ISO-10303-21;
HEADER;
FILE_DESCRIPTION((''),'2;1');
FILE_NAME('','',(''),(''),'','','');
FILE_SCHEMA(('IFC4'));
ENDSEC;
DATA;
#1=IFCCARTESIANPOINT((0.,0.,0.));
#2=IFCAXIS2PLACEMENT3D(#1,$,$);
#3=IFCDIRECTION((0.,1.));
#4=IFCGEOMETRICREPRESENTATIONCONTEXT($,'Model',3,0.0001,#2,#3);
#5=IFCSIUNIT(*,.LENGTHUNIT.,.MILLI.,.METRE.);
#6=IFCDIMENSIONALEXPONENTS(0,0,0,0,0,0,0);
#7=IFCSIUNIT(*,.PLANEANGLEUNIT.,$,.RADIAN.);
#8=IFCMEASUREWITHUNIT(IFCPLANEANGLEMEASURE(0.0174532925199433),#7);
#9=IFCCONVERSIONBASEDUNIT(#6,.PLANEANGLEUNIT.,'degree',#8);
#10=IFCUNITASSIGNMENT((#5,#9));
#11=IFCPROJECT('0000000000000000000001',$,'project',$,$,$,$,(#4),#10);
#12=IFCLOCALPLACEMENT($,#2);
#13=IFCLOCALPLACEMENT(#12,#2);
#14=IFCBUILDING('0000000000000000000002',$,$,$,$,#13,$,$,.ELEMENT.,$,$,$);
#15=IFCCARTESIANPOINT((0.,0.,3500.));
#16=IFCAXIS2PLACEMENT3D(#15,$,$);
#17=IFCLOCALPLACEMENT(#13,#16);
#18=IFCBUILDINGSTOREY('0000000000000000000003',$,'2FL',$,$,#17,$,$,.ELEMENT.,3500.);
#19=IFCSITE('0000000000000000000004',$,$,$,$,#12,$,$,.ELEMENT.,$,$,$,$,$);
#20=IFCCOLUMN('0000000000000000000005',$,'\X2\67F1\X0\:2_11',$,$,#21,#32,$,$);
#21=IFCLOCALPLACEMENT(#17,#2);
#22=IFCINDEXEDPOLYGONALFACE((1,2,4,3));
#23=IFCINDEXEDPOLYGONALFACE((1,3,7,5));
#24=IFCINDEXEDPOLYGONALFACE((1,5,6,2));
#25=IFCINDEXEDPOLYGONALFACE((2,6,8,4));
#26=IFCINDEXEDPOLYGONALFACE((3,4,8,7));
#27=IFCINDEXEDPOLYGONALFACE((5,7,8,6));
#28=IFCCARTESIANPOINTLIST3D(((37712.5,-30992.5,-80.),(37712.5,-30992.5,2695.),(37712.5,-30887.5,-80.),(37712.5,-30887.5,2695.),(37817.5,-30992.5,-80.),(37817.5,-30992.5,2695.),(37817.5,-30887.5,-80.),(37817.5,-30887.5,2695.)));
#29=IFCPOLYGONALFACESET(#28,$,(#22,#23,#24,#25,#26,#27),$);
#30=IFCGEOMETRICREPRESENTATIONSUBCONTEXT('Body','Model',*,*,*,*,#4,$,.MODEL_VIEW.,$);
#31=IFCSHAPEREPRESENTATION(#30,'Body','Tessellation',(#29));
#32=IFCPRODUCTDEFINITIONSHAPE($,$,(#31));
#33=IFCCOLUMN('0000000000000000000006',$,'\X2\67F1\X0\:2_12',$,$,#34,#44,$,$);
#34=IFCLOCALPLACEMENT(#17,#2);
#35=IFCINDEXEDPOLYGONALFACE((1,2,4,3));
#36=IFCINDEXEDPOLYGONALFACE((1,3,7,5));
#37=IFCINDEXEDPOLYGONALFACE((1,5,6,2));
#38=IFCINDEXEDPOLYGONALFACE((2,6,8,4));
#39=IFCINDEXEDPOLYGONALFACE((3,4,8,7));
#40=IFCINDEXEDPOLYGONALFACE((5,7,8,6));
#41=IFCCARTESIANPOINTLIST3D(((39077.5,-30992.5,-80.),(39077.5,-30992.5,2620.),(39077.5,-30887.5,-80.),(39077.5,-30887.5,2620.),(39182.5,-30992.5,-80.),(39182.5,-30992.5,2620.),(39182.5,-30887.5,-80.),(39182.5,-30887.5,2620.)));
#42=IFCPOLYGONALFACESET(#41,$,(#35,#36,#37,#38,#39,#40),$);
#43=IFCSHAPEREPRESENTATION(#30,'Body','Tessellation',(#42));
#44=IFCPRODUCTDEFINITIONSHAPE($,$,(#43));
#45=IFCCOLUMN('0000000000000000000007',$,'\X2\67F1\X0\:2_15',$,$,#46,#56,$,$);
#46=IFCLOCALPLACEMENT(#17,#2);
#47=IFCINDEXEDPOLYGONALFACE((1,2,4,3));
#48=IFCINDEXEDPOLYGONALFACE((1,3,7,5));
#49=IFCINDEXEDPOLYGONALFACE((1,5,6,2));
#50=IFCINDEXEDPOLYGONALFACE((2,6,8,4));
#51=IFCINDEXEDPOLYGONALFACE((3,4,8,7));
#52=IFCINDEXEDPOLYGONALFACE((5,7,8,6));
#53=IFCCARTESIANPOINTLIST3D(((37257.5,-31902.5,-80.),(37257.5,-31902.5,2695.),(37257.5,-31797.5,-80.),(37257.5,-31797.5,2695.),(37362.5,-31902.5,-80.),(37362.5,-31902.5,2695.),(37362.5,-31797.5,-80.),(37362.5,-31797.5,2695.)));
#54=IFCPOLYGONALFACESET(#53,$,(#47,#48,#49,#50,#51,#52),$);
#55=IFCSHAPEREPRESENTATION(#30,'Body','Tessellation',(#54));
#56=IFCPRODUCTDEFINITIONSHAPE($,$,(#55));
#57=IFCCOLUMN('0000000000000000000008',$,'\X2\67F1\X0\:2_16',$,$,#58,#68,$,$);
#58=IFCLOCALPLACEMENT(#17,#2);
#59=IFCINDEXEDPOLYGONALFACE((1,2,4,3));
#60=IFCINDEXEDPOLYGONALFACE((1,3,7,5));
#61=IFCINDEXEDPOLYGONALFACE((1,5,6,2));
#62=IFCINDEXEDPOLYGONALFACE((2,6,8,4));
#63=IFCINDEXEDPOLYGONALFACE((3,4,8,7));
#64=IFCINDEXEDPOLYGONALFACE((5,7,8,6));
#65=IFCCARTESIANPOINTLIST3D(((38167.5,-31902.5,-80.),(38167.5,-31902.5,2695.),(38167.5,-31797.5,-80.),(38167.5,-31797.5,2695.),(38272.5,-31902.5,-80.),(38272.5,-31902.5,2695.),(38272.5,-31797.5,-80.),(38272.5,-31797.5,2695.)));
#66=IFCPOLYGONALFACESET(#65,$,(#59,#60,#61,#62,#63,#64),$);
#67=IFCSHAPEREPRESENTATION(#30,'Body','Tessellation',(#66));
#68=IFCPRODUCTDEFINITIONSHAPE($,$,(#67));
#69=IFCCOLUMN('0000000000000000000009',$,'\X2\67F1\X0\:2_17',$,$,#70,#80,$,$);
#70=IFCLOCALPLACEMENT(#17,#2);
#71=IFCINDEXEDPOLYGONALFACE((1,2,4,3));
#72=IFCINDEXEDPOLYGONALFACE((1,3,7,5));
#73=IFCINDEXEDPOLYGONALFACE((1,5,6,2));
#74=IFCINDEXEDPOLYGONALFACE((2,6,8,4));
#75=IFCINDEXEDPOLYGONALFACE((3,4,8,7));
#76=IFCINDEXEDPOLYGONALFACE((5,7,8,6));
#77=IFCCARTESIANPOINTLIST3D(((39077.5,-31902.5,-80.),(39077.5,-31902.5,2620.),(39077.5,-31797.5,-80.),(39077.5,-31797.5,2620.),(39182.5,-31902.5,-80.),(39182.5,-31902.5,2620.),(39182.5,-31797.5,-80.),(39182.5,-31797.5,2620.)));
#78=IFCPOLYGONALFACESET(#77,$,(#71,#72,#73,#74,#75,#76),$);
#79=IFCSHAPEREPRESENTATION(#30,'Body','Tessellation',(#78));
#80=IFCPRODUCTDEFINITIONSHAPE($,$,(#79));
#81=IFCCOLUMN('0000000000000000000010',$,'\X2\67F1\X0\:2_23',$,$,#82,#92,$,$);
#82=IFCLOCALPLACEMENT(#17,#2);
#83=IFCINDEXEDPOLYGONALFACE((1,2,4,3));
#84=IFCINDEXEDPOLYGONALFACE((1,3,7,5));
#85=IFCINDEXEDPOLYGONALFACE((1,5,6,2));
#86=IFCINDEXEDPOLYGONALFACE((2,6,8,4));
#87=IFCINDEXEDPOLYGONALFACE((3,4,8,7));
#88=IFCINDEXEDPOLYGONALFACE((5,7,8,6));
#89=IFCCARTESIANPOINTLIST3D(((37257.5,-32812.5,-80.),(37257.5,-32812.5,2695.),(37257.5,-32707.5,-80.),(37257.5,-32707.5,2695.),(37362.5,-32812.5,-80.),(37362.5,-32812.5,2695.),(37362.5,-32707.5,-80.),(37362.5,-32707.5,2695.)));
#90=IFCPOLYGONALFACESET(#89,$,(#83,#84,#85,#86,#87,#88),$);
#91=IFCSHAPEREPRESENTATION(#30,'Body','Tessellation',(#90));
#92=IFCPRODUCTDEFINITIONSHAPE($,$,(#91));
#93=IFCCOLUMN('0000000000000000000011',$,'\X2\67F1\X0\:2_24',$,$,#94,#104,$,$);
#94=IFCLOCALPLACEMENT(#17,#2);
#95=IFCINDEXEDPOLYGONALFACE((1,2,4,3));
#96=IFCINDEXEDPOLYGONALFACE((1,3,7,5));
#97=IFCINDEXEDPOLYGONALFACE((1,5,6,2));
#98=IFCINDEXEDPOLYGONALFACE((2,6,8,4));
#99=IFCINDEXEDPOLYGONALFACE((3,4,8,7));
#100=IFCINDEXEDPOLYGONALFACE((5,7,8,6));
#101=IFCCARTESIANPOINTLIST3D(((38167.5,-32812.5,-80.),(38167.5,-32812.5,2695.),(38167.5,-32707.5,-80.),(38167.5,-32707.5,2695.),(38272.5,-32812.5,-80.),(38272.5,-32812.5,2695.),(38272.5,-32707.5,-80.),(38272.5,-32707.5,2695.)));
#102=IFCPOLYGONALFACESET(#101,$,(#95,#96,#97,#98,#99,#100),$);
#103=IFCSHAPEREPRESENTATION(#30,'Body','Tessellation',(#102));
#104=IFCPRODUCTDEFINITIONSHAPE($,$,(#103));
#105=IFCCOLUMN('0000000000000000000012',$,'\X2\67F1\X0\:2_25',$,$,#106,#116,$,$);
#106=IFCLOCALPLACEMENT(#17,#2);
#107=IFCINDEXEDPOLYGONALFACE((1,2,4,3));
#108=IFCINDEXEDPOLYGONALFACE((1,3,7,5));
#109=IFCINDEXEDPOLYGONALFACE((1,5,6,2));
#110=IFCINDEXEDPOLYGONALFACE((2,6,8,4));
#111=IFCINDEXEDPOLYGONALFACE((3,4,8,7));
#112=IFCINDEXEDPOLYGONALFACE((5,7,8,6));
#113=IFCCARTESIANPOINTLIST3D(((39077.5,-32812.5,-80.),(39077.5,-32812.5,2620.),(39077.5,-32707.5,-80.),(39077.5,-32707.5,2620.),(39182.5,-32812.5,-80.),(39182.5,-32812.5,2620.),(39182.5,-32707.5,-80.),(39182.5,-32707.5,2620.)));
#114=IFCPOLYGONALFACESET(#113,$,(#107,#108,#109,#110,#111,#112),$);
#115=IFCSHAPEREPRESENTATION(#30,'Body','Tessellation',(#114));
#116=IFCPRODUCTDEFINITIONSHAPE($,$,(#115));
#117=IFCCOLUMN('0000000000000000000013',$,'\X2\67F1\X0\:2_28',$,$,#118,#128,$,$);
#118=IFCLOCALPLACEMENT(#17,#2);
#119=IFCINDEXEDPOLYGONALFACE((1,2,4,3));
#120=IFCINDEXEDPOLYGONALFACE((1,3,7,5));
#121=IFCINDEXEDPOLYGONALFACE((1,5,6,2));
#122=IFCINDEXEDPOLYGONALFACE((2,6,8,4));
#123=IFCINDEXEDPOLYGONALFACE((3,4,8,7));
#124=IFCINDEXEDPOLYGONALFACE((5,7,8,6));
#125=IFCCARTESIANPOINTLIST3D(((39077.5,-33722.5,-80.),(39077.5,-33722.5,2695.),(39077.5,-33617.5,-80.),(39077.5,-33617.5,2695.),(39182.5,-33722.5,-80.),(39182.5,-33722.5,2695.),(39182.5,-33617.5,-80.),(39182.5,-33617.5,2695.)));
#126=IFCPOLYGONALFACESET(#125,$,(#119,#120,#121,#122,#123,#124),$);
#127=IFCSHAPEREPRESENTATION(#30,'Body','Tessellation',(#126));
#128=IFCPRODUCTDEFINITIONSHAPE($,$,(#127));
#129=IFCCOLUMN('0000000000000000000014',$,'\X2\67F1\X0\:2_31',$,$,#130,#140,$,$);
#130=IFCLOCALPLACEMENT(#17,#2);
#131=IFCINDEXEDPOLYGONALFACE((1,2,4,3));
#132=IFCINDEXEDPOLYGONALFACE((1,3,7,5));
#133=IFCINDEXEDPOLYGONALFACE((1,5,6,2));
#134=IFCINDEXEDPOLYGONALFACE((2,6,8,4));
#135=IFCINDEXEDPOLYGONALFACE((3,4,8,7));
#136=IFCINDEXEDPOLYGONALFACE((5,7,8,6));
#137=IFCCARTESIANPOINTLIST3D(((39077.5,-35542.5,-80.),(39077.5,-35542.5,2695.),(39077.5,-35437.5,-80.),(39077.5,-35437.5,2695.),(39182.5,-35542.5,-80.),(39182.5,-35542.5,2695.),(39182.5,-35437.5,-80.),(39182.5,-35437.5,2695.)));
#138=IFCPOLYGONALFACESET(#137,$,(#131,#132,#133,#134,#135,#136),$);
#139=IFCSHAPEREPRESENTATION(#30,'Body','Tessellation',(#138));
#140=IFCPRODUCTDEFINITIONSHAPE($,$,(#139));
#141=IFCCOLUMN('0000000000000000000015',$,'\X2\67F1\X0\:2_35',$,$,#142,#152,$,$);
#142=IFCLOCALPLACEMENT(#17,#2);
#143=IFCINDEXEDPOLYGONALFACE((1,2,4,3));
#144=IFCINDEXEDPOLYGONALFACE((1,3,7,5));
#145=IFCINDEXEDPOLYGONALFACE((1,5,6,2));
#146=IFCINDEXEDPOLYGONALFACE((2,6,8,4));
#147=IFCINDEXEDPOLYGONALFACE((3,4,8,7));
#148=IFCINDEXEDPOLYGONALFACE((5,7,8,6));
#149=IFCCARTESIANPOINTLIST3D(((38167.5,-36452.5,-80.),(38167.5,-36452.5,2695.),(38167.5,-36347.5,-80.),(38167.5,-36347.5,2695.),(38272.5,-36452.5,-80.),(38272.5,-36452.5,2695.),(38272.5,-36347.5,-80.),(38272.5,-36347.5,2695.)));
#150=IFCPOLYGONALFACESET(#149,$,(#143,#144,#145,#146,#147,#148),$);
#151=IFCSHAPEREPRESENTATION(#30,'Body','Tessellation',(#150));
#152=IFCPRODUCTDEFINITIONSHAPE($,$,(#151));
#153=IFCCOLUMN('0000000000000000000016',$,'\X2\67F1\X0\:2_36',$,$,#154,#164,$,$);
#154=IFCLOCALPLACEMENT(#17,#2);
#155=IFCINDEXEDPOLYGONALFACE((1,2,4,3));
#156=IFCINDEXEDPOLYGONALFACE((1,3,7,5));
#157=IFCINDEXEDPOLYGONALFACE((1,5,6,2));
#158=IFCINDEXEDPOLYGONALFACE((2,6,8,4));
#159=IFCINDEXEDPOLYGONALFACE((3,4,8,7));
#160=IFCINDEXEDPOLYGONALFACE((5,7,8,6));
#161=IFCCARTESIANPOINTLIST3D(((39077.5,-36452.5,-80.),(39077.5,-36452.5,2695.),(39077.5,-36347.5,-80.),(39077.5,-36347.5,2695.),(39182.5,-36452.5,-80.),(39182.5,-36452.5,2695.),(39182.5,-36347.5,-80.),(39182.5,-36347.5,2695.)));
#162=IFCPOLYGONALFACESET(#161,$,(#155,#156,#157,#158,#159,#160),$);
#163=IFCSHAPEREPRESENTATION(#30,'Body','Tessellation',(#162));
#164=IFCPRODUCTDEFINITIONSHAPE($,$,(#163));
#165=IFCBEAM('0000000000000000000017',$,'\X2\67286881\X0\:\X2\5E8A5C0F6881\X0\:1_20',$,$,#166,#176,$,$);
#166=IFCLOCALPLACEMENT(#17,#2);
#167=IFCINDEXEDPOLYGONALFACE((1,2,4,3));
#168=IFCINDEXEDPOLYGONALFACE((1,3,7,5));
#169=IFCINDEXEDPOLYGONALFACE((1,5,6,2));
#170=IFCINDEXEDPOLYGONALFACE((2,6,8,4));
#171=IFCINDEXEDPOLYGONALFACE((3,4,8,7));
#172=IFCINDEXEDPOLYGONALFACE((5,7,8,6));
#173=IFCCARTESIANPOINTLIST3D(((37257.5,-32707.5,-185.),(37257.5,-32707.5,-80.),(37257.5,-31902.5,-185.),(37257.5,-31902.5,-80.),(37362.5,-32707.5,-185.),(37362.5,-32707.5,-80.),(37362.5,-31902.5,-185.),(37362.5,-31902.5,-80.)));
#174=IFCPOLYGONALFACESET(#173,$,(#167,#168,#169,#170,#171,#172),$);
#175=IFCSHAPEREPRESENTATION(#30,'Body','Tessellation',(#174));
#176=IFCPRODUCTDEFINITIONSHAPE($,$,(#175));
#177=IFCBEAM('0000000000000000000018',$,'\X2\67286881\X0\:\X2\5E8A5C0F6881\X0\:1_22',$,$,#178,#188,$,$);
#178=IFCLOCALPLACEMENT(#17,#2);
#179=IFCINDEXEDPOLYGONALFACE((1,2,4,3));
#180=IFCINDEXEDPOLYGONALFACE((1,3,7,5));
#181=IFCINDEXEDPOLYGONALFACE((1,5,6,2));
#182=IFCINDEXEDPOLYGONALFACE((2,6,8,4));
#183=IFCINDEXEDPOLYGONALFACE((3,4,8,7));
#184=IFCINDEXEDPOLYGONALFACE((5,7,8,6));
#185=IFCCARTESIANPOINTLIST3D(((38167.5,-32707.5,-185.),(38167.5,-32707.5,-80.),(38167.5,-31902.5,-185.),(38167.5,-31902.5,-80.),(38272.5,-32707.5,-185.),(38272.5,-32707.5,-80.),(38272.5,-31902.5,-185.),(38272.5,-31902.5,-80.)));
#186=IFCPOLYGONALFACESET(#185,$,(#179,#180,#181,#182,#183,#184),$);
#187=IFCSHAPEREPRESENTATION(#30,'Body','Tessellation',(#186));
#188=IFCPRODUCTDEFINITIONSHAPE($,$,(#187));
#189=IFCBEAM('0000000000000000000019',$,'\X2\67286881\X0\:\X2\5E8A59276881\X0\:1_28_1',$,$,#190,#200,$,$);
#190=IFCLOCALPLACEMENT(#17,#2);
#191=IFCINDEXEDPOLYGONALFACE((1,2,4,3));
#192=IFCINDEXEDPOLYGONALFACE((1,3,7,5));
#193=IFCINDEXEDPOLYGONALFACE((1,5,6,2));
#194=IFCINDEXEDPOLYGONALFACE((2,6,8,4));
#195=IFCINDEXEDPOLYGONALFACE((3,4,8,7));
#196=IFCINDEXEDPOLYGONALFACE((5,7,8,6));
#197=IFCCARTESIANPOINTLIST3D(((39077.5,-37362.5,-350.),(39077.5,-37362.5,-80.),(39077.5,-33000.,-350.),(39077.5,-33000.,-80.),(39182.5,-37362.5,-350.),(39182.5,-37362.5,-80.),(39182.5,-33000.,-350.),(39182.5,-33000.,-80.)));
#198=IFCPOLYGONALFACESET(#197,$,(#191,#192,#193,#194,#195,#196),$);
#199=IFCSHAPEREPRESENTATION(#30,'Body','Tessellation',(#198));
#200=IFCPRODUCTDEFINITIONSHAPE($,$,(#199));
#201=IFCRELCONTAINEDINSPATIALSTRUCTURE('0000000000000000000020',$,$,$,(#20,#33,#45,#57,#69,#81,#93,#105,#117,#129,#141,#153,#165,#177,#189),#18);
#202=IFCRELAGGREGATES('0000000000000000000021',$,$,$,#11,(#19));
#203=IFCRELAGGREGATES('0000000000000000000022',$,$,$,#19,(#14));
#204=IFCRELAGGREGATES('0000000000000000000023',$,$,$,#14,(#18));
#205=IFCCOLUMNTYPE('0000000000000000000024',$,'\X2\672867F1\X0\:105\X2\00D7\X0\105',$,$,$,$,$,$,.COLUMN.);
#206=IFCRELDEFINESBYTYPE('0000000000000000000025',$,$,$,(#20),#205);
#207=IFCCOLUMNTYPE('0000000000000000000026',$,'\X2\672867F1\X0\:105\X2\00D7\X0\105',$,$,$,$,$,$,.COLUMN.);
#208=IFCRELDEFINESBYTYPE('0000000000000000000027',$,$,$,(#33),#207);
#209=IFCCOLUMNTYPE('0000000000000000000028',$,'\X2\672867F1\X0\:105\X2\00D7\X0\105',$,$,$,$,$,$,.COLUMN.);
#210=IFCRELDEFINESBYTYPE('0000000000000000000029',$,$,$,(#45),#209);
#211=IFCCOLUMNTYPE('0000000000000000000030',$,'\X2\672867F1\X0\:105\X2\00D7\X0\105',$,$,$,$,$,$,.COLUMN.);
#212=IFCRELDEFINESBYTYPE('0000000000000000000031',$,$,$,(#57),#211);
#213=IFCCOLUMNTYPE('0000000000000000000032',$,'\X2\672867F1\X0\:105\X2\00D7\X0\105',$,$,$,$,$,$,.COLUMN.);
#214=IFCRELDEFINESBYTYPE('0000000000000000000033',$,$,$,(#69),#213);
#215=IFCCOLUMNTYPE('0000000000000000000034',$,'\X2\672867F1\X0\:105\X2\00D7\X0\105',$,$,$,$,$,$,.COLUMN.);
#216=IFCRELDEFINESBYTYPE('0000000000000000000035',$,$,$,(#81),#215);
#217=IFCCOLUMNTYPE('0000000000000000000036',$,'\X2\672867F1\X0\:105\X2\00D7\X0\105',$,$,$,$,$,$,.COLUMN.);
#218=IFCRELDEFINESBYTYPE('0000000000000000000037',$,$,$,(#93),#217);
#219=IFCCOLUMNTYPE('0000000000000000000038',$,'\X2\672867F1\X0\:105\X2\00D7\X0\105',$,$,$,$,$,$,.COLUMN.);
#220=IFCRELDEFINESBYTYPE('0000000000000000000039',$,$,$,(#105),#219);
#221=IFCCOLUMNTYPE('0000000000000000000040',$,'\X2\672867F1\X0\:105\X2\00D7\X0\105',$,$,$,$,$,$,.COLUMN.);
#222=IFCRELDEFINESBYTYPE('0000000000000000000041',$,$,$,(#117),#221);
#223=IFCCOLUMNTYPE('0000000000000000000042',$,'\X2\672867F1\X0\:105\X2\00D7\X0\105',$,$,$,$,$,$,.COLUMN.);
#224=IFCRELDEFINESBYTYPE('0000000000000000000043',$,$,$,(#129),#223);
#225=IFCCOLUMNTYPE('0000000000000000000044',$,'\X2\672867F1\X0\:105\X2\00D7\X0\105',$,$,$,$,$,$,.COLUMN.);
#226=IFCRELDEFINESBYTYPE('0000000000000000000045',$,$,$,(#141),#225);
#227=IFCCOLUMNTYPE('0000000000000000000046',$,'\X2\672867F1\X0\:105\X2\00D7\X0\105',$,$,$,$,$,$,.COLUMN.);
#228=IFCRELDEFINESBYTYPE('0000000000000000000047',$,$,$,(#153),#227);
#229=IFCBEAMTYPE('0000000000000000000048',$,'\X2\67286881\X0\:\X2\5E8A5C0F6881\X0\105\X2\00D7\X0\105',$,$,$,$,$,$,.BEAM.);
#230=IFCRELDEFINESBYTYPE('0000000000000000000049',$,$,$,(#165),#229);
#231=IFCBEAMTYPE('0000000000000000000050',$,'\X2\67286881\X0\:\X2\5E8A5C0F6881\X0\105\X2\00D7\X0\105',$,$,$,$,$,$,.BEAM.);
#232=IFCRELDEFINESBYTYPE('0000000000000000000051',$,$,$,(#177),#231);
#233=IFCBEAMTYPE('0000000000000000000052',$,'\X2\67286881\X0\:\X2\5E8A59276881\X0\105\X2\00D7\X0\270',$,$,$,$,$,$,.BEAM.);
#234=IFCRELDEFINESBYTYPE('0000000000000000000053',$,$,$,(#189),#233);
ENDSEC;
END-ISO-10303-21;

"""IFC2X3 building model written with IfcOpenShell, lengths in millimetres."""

from ifc_helpers import new_model, entity, si_unit, converted_unit, direction, frame, origin, origin_with_axes, origin_2d, place, context, subcontext, project, spatial, rectangle, extrude, type_object, element, save


model = new_model("IFC2X3")

# Units and contexts
model_context = context("Model", 3, precision=0.0001, world=origin(), true_north=direction((0.0, 1.0)))
body_context = subcontext(model_context, "Body", "Model", "MODEL_VIEW")
ifc_project = project(units=[si_unit("LENGTHUNIT", "METRE", prefix="MILLI"), converted_unit("PLANEANGLEUNIT", "degree", entity("IfcPlaneAngleMeasure", 0.0174532925199433), si_unit("PLANEANGLEUNIT", "RADIAN"), dimensions=[0, 0, 0, 0, 0, 0, 0])], contexts=[model_context])

# Site, building, storey
site_placement = place(None, origin())
site = spatial("IfcSite", under=ifc_project, at=site_placement, CompositionType="ELEMENT")
building_placement = place(site_placement, origin())
building = spatial("IfcBuilding", under=site, at=building_placement, CompositionType="ELEMENT")
storey_placement = place(building_placement, frame((0.0, 0.0, 3500.0)))
storey = spatial("IfcBuildingStorey", under=building, at=storey_placement, Name="2FL", CompositionType="ELEMENT", Elevation=3500.0)

# Columns
column_type_1 = type_object("IfcColumnType", Name="木柱:105×105", PredefinedType="COLUMN")
column_1_placement = place(storey_placement, frame((37765.0, -30940.0, -80.0)))
element("IfcColumn", 1, at=column_1_placement, inside=storey, type_object=column_type_1, Name="柱:2_11", context=body_context, shape_type="SweptSolid", body=[
    extrude(rectangle(XDim=105.0, YDim=105.0, at=origin_2d()), origin_with_axes(), (0.0, 0.0, 1.0), 2775.0),
])
column_type_2 = type_object("IfcColumnType", Name="木柱:105×105", PredefinedType="COLUMN")
column_2_placement = place(storey_placement, frame((39130.0, -30940.0, -80.0)))
element("IfcColumn", 2, at=column_2_placement, inside=storey, type_object=column_type_2, Name="柱:2_12", context=body_context, shape_type="SweptSolid", body=[
    extrude(rectangle(XDim=105.0, YDim=105.0, at=origin_2d()), origin_with_axes(), (0.0, 0.0, 1.0), 2700.0),
])
column_type_3 = type_object("IfcColumnType", Name="木柱:105×105", PredefinedType="COLUMN")
column_3_placement = place(storey_placement, frame((37310.0, -31850.0, -80.0)))
element("IfcColumn", 3, at=column_3_placement, inside=storey, type_object=column_type_3, Name="柱:2_15", context=body_context, shape_type="SweptSolid", body=[
    extrude(rectangle(XDim=105.0, YDim=105.0, at=origin_2d()), origin_with_axes(), (0.0, 0.0, 1.0), 2775.0),
])
column_type_4 = type_object("IfcColumnType", Name="木柱:105×105", PredefinedType="COLUMN")
column_4_placement = place(storey_placement, frame((38220.0, -31850.0, -80.0)))
element("IfcColumn", 4, at=column_4_placement, inside=storey, type_object=column_type_4, Name="柱:2_16", context=body_context, shape_type="SweptSolid", body=[
    extrude(rectangle(XDim=105.0, YDim=105.0, at=origin_2d()), origin_with_axes(), (0.0, 0.0, 1.0), 2775.0),
])
column_type_5 = type_object("IfcColumnType", Name="木柱:105×105", PredefinedType="COLUMN")
column_5_placement = place(storey_placement, frame((39130.0, -31850.0, -80.0)))
element("IfcColumn", 5, at=column_5_placement, inside=storey, type_object=column_type_5, Name="柱:2_17", context=body_context, shape_type="SweptSolid", body=[
    extrude(rectangle(XDim=105.0, YDim=105.0, at=origin_2d()), origin_with_axes(), (0.0, 0.0, 1.0), 2700.0),
])
column_type_6 = type_object("IfcColumnType", Name="木柱:105×105", PredefinedType="COLUMN")
column_6_placement = place(storey_placement, frame((37310.0, -32760.0, -80.0)))
element("IfcColumn", 6, at=column_6_placement, inside=storey, type_object=column_type_6, Name="柱:2_23", context=body_context, shape_type="SweptSolid", body=[
    extrude(rectangle(XDim=105.0, YDim=105.0, at=origin_2d()), origin_with_axes(), (0.0, 0.0, 1.0), 2775.0),
])
column_type_7 = type_object("IfcColumnType", Name="木柱:105×105", PredefinedType="COLUMN")
column_7_placement = place(storey_placement, frame((38220.0, -32760.0, -80.0)))
element("IfcColumn", 7, at=column_7_placement, inside=storey, type_object=column_type_7, Name="柱:2_24", context=body_context, shape_type="SweptSolid", body=[
    extrude(rectangle(XDim=105.0, YDim=105.0, at=origin_2d()), origin_with_axes(), (0.0, 0.0, 1.0), 2775.0),
])
column_type_8 = type_object("IfcColumnType", Name="木柱:105×105", PredefinedType="COLUMN")
column_8_placement = place(storey_placement, frame((39130.0, -32760.0, -80.0)))
element("IfcColumn", 8, at=column_8_placement, inside=storey, type_object=column_type_8, Name="柱:2_25", context=body_context, shape_type="SweptSolid", body=[
    extrude(rectangle(XDim=105.0, YDim=105.0, at=origin_2d()), origin_with_axes(), (0.0, 0.0, 1.0), 2700.0),
])
column_type_9 = type_object("IfcColumnType", Name="木柱:105×105", PredefinedType="COLUMN")
column_9_placement = place(storey_placement, frame((39130.0, -33670.0, -80.0)))
element("IfcColumn", 9, at=column_9_placement, inside=storey, type_object=column_type_9, Name="柱:2_28", context=body_context, shape_type="SweptSolid", body=[
    extrude(rectangle(XDim=105.0, YDim=105.0, at=origin_2d()), origin_with_axes(), (0.0, 0.0, 1.0), 2775.0),
])
column_type_10 = type_object("IfcColumnType", Name="木柱:105×105", PredefinedType="COLUMN")
column_10_placement = place(storey_placement, frame((39130.0, -35490.0, -80.0)))
element("IfcColumn", 10, at=column_10_placement, inside=storey, type_object=column_type_10, Name="柱:2_31", context=body_context, shape_type="SweptSolid", body=[
    extrude(rectangle(XDim=105.0, YDim=105.0, at=origin_2d()), origin_with_axes(), (0.0, 0.0, 1.0), 2775.0),
])
column_type_11 = type_object("IfcColumnType", Name="木柱:105×105", PredefinedType="COLUMN")
column_11_placement = place(storey_placement, frame((38220.0, -36400.0, -80.0)))
element("IfcColumn", 11, at=column_11_placement, inside=storey, type_object=column_type_11, Name="柱:2_35", context=body_context, shape_type="SweptSolid", body=[
    extrude(rectangle(XDim=105.0, YDim=105.0, at=origin_2d()), origin_with_axes(), (0.0, 0.0, 1.0), 2775.0),
])
column_type_12 = type_object("IfcColumnType", Name="木柱:105×105", PredefinedType="COLUMN")
column_12_placement = place(storey_placement, frame((39130.0, -36400.0, -80.0)))
element("IfcColumn", 12, at=column_12_placement, inside=storey, type_object=column_type_12, Name="柱:2_36", context=body_context, shape_type="SweptSolid", body=[
    extrude(rectangle(XDim=105.0, YDim=105.0, at=origin_2d()), origin_with_axes(), (0.0, 0.0, 1.0), 2775.0),
])

# Beams
beam_type_1 = type_object("IfcBeamType", Name="木梁:床小梁105×105", PredefinedType="BEAM")
beam_1_placement = place(storey_placement, frame((37310.0, -31902.5, -132.5), z_axis=(0.0, -1.0, 0.0), x_axis=(1.0, 0.0, 0.0)))
element("IfcBeam", 13, at=beam_1_placement, inside=storey, type_object=beam_type_1, Name="木梁:床小梁:1_20", context=body_context, shape_type="SweptSolid", body=[
    extrude(rectangle(XDim=105.0, YDim=105.0, at=origin_2d()), origin_with_axes(), (0.0, 0.0, 1.0), 805.0),
])
beam_type_2 = type_object("IfcBeamType", Name="木梁:床小梁105×105", PredefinedType="BEAM")
beam_2_placement = place(storey_placement, frame((38220.0, -31902.5, -132.5), z_axis=(0.0, -1.0, 0.0), x_axis=(1.0, 0.0, 0.0)))
element("IfcBeam", 14, at=beam_2_placement, inside=storey, type_object=beam_type_2, Name="木梁:床小梁:1_22", context=body_context, shape_type="SweptSolid", body=[
    extrude(rectangle(XDim=105.0, YDim=105.0, at=origin_2d()), origin_with_axes(), (0.0, 0.0, 1.0), 805.0),
])
beam_type_3 = type_object("IfcBeamType", Name="木梁:床大梁105×270", PredefinedType="BEAM")
beam_3_placement = place(storey_placement, frame((39130.0, -33000.0, -215.0), z_axis=(0.0, -1.0, 0.0), x_axis=(1.0, 0.0, 0.0)))
element("IfcBeam", 15, at=beam_3_placement, inside=storey, type_object=beam_type_3, Name="木梁:床大梁:1_28_1", context=body_context, shape_type="SweptSolid", body=[
    extrude(rectangle(XDim=105.0, YDim=270.0, at=origin_2d()), origin_with_axes(), (0.0, 0.0, 1.0), 4362.5),
])

save(model, "model.ifc")
